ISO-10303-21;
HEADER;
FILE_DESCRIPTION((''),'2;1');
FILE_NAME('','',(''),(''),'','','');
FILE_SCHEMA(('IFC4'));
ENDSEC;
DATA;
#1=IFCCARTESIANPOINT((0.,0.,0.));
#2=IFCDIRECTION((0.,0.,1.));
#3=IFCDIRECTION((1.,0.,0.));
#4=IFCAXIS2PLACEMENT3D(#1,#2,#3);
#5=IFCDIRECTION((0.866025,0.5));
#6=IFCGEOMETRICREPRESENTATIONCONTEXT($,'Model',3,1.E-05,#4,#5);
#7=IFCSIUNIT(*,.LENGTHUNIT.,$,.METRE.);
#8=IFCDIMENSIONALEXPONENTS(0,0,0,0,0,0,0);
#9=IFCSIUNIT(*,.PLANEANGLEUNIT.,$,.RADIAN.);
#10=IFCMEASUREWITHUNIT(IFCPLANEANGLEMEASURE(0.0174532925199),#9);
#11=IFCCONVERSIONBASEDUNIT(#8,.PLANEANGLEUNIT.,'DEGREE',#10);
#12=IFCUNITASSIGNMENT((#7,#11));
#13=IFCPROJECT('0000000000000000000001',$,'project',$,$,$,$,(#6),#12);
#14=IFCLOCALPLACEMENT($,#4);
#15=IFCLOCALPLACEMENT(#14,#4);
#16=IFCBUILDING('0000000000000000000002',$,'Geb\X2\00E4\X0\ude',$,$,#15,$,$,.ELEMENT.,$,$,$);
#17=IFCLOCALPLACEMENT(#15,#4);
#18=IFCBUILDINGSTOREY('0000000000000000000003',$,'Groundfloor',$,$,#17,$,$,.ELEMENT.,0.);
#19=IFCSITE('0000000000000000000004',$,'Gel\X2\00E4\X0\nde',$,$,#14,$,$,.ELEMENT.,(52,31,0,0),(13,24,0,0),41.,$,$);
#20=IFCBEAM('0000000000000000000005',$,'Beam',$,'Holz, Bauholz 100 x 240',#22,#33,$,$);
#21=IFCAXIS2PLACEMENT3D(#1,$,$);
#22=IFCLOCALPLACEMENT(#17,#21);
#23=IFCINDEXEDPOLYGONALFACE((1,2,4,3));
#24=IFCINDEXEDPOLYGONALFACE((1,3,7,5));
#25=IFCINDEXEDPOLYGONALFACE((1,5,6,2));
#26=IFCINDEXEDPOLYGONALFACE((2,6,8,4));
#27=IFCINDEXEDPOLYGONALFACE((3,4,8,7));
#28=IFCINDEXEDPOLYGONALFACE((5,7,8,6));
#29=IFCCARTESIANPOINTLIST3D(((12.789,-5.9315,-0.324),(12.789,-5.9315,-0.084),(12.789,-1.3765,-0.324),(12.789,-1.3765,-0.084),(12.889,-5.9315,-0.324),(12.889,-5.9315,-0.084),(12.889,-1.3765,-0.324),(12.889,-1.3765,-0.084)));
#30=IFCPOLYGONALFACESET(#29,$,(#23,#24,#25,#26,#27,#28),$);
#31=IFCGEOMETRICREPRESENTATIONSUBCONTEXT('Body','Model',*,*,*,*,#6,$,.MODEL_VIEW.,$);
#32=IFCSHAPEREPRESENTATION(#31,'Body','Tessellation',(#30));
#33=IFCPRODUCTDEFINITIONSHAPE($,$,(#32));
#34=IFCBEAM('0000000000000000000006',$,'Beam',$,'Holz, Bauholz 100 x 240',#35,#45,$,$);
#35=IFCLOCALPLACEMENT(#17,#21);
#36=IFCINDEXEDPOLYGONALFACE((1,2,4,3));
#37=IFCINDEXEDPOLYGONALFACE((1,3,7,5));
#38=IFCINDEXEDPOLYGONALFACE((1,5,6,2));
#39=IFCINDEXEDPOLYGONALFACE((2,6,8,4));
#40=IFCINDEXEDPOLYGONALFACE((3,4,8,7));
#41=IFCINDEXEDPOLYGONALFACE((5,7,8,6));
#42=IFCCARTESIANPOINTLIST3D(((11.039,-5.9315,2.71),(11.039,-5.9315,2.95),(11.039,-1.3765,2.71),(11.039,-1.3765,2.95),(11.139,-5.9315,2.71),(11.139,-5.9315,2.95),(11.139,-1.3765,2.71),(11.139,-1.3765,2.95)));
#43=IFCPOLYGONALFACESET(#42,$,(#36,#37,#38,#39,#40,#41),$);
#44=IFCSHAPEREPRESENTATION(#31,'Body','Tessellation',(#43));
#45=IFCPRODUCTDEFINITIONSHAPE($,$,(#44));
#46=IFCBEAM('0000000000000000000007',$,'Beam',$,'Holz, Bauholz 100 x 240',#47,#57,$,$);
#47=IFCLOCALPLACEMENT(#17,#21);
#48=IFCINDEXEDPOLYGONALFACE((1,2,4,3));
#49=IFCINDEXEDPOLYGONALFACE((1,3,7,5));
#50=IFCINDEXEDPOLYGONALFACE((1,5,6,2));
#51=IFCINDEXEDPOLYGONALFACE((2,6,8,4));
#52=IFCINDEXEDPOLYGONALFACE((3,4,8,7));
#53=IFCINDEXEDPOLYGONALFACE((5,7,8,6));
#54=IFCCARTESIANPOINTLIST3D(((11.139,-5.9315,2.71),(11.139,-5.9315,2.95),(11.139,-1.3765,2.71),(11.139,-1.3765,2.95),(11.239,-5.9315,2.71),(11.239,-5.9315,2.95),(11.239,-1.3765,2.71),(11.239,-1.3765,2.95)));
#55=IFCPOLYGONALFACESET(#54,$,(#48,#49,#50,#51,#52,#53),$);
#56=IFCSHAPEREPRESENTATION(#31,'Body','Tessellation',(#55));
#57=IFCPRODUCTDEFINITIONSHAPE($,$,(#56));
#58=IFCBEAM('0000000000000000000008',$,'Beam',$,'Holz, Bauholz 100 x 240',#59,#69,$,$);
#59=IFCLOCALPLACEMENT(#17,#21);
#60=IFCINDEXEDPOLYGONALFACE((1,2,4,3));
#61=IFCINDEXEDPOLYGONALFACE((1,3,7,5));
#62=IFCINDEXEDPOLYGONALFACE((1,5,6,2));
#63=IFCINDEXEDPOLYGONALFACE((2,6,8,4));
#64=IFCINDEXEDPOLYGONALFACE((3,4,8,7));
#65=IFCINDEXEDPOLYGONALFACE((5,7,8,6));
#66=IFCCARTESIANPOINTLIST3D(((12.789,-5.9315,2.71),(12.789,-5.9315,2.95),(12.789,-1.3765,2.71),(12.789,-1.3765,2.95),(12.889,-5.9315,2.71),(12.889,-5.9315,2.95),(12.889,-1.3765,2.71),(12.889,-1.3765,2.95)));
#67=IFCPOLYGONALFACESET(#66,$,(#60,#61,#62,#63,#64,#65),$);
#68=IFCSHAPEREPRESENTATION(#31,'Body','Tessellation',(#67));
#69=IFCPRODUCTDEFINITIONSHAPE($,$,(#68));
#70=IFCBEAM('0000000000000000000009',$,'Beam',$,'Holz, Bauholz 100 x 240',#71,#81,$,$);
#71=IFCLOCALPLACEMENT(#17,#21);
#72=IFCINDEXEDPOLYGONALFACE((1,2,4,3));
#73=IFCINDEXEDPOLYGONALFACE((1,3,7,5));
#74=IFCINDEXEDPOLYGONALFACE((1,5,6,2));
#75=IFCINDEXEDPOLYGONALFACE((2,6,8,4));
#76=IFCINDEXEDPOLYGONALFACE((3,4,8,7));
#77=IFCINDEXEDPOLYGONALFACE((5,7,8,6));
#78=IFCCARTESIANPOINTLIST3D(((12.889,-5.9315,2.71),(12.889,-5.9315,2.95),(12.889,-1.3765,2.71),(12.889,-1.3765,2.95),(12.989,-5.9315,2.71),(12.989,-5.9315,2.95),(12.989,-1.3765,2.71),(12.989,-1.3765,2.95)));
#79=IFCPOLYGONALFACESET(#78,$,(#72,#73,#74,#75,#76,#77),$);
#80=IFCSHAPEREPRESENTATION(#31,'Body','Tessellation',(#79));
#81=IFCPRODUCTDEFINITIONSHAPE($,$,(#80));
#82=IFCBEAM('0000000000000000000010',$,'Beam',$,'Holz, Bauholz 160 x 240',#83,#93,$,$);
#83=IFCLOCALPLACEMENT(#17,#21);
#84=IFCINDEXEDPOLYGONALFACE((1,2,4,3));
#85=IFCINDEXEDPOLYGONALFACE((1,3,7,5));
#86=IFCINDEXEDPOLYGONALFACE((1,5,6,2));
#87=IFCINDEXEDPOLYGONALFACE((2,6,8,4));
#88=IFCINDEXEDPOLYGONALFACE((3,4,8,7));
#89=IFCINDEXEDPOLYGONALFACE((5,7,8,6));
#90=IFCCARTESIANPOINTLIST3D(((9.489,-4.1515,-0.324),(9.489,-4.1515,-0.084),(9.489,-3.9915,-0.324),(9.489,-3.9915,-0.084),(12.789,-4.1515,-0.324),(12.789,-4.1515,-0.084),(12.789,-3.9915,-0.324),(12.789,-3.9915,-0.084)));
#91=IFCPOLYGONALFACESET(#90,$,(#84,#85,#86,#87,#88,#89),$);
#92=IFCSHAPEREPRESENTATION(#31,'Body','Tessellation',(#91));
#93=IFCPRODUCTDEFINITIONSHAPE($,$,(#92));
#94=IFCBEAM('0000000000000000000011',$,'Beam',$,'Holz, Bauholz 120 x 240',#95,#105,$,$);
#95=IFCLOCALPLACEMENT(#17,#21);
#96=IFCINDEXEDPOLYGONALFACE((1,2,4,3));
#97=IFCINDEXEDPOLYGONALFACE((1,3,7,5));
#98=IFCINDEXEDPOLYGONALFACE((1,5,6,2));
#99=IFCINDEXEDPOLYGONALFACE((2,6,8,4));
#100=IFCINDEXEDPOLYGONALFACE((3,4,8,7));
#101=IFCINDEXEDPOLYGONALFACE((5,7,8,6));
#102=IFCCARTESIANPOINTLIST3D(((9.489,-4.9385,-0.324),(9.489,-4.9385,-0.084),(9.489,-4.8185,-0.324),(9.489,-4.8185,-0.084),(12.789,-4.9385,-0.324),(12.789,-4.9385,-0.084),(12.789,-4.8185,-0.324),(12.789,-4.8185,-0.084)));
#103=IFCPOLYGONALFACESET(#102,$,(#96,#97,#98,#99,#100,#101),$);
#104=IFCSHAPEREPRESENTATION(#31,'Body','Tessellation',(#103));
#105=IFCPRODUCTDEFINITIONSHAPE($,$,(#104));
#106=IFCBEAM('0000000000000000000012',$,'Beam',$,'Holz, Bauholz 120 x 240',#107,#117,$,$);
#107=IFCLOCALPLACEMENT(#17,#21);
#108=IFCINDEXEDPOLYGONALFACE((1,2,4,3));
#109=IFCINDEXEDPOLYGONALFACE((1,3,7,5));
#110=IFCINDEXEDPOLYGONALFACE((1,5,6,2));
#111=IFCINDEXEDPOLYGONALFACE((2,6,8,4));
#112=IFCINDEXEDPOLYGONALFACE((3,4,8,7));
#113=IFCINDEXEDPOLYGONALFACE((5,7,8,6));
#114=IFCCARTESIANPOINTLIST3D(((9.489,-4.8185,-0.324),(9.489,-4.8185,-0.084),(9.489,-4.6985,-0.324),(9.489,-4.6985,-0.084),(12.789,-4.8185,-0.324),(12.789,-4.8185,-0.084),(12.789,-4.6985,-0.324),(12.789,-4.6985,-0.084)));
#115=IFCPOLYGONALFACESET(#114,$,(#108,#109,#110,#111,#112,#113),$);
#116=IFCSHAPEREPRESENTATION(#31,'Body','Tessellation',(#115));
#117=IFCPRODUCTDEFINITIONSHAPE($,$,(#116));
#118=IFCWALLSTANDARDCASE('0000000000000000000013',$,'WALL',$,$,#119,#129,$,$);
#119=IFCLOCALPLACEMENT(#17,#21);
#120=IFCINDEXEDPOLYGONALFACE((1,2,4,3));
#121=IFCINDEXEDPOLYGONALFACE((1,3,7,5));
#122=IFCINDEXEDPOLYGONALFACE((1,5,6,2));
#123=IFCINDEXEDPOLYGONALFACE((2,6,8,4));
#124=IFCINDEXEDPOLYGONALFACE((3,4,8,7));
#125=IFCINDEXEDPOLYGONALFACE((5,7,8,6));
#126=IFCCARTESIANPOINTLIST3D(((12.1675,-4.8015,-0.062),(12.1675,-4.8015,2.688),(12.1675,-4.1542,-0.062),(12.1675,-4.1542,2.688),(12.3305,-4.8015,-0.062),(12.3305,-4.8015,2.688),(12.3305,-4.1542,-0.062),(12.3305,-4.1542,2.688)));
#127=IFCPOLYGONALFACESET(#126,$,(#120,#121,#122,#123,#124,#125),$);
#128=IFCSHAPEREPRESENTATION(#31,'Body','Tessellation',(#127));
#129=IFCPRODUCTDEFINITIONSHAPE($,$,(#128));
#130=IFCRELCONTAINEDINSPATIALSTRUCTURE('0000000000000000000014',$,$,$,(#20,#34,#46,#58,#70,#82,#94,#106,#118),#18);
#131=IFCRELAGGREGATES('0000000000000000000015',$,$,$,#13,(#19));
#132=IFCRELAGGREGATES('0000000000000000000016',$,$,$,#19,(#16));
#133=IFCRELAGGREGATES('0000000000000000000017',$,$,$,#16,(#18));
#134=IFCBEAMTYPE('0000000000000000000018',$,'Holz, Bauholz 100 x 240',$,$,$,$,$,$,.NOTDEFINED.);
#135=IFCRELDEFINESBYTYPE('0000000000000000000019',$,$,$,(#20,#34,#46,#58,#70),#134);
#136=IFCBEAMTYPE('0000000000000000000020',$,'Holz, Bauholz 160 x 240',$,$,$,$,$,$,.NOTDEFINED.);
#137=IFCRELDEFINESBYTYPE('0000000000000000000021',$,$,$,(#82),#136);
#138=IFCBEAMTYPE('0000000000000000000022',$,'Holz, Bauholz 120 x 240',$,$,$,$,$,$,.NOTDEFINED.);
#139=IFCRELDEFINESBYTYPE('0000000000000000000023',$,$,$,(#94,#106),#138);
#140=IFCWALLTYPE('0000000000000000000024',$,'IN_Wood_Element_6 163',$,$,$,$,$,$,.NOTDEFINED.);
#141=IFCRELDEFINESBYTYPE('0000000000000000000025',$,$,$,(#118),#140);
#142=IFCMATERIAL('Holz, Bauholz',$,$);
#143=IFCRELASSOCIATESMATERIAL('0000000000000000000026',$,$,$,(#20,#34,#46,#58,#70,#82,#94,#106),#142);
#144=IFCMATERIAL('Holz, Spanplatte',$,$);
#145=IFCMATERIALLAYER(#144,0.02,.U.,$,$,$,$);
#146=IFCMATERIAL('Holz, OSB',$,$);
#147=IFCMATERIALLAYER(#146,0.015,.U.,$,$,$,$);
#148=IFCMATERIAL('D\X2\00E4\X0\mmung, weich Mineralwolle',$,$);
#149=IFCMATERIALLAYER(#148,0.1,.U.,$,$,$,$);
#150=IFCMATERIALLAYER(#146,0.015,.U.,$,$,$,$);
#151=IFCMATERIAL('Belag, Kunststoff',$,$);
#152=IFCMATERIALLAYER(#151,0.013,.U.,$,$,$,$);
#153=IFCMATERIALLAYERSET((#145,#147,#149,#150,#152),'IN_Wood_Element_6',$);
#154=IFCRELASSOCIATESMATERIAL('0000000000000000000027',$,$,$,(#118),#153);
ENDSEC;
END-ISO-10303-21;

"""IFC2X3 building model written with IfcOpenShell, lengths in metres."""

from ifc_helpers import new_model, entity, si_unit, converted_unit, direction, frame, frame_2d, origin_with_axes, place, context, subcontext, project, spatial, polyline, rectangle, outline, extrude, material, layer, layer_set, layer_usage, type_object, element, save


model = new_model("IFC2X3")

# Units and contexts
model_context = context("Model", 3, precision=1e-05, world=origin_with_axes(), true_north=direction((0.866025, 0.5)))
body_context = subcontext(model_context, "Body", "Model", "MODEL_VIEW")
ifc_project = project(units=[si_unit("LENGTHUNIT", "METRE"), converted_unit("PLANEANGLEUNIT", "DEGREE", entity("IfcPlaneAngleMeasure", 0.0174532925199), si_unit("PLANEANGLEUNIT", "RADIAN"), dimensions=[0, 0, 0, 0, 0, 0, 0])], contexts=[model_context])

# Site, building, storey
site_placement = place(None, origin_with_axes())
site = spatial("IfcSite", under=ifc_project, at=site_placement, Name="Gelände", CompositionType="ELEMENT", RefLatitude=(52, 31, 0, 0), RefLongitude=(13, 24, 0, 0), RefElevation=41.0)
building_placement = place(site_placement, origin_with_axes())
building = spatial("IfcBuilding", under=site, at=building_placement, Name="Gebäude", CompositionType="ELEMENT")
storey_placement = place(building_placement, origin_with_axes())
storey = spatial("IfcBuildingStorey", under=building, at=storey_placement, Name="Groundfloor", CompositionType="ELEMENT", Elevation=0.0)

# Shared definitions
ifc_material_1 = material(Name="Holz, Bauholz")

# Beams
beam_type_1 = type_object("IfcBeamType", Name="Holz, Bauholz 100 x 240", PredefinedType="NOTDEFINED")
for number, where, z_axis, x_axis, name in (
    (1, (12.839, -5.9315, -0.084), (0.0, 0.0, 1.0), (1.0, 0.0, 0.0), "Beam"),
):
    element("IfcBeam", number, at=place(storey_placement, frame(where, z_axis=z_axis, x_axis=x_axis)), inside=storey, type_object=beam_type_1, material=ifc_material_1, Name=name, ObjectType="Holz, Bauholz 100 x 240", context=body_context, shape_type="SweptSolid", body=[
        extrude(rectangle(XDim=0.24, YDim=0.1, at=frame_2d((-0.12, 0.0), x_axis=(1.0, 0.0))), frame((0.0, 0.0, 0.0), z_axis=(0.0, 1.0, 0.0), x_axis=(0.0, 0.0, 1.0)), (0.0, 0.0, 1.0), 4.555),
    ])
for number, where, z_axis, x_axis, name in (
    (2, (11.089, -5.9315, 2.95), (0.0, 0.0, 1.0), (1.0, 0.0, 0.0), "Beam"),
    (3, (11.189, -5.9315, 2.95), (0.0, 0.0, 1.0), (1.0, 0.0, 0.0), "Beam"),
    (4, (12.839, -5.9315, 2.95), (0.0, 0.0, 1.0), (1.0, 0.0, 0.0), "Beam"),
    (5, (12.939, -5.9315, 2.95), (0.0, 0.0, 1.0), (1.0, 0.0, 0.0), "Beam"),
):
    element("IfcBeam", number, at=place(storey_placement, frame(where, z_axis=z_axis, x_axis=x_axis)), inside=storey, type_object=beam_type_1, material=ifc_material_1, Name=name, ObjectType="Holz, Bauholz 100 x 240", context=body_context, shape_type="SweptSolid", body=[
        extrude(rectangle(XDim=0.24, YDim=0.1, at=frame_2d((-0.12, 0.0), x_axis=(1.0, 0.0))), frame((0.0, 0.0, 0.0), z_axis=(0.0, 1.0, 0.0), x_axis=(0.0, 0.0, 1.0)), (0.0, 0.0, 1.0), 4.555),
    ])
beam_type_2 = type_object("IfcBeamType", Name="Holz, Bauholz 160 x 240", PredefinedType="NOTDEFINED")
beam_placement = place(storey_placement, frame((12.789, -4.0715, -0.084), z_axis=(0.0, 0.0, 1.0), x_axis=(0.0, 1.0, 0.0)))
element("IfcBeam", 6, at=beam_placement, inside=storey, type_object=beam_type_2, material=ifc_material_1, Name="Beam", ObjectType="Holz, Bauholz 160 x 240", context=body_context, shape_type="SweptSolid", body=[
    extrude(rectangle(XDim=0.24, YDim=0.16, at=frame_2d((-0.12, 0.0), x_axis=(1.0, 0.0))), frame((0.0, 0.0, 0.0), z_axis=(0.0, 1.0, 0.0), x_axis=(0.0, 0.0, 1.0)), (0.0, 0.0, 1.0), 3.3),
])
beam_type_3 = type_object("IfcBeamType", Name="Holz, Bauholz 120 x 240", PredefinedType="NOTDEFINED")
for number, where, z_axis, x_axis, name in (
    (7, (12.789, -4.8785, -0.084), (0.0, 0.0, 1.0), (0.0, 1.0, 0.0), "Beam"),
    (8, (12.789, -4.7585, -0.084), (0.0, 0.0, 1.0), (0.0, 1.0, 0.0), "Beam"),
):
    element("IfcBeam", number, at=place(storey_placement, frame(where, z_axis=z_axis, x_axis=x_axis)), inside=storey, type_object=beam_type_3, material=ifc_material_1, Name=name, ObjectType="Holz, Bauholz 120 x 240", context=body_context, shape_type="SweptSolid", body=[
        extrude(rectangle(XDim=0.24, YDim=0.12, at=frame_2d((-0.12, 0.0), x_axis=(1.0, 0.0))), frame((0.0, 0.0, 0.0), z_axis=(0.0, 1.0, 0.0), x_axis=(0.0, 0.0, 1.0)), (0.0, 0.0, 1.0), 3.3),
    ])

# Wall
ifc_material_2 = material(Name="Holz, Spanplatte")
ifc_layer_1 = layer(ifc_material_2, 0.02, ventilated="UNKNOWN")
ifc_material_3 = material(Name="Holz, OSB")
ifc_layer_2 = layer(ifc_material_3, 0.015, ventilated="UNKNOWN")
ifc_material_4 = material(Name="Dämmung, weich Mineralwolle")
ifc_layer_3 = layer(ifc_material_4, 0.1, ventilated="UNKNOWN")
ifc_layer_4 = layer(ifc_material_3, 0.015, ventilated="UNKNOWN")
ifc_material_5 = material(Name="Belag, Kunststoff")
ifc_layer_5 = layer(ifc_material_5, 0.013, ventilated="UNKNOWN")
ifc_layer_set = layer_set([ifc_layer_1, ifc_layer_2, ifc_layer_3, ifc_layer_4, ifc_layer_5], Name="IN_Wood_Element_6")
ifc_layer_usage = layer_usage(ifc_layer_set, "AXIS2", "NEGATIVE", 0.163)
wall_type = type_object("IfcWallType", Name="IN_Wood_Element_6 163", PredefinedType="NOTDEFINED")
wall_placement = place(storey_placement, frame((12.1675, -4.1542, -0.062), z_axis=(0.0, 0.0, 1.0), x_axis=(0.0, -1.0, 0.0)))
element("IfcWallStandardCase", 9, at=wall_placement, inside=storey, type_object=wall_type, material=ifc_layer_usage, Name="WALL", context=body_context, shape_type="SweptSolid", body=[
    extrude(outline(polyline([(0.0, 0.0), (0.6472, 0.0), (0.6472, 0.163), (0.0, 0.163), (0.0, 0.0)])), origin_with_axes(), (0.0, 0.0, 1.0), 2.75),
])

save(model, "model.ifc")
